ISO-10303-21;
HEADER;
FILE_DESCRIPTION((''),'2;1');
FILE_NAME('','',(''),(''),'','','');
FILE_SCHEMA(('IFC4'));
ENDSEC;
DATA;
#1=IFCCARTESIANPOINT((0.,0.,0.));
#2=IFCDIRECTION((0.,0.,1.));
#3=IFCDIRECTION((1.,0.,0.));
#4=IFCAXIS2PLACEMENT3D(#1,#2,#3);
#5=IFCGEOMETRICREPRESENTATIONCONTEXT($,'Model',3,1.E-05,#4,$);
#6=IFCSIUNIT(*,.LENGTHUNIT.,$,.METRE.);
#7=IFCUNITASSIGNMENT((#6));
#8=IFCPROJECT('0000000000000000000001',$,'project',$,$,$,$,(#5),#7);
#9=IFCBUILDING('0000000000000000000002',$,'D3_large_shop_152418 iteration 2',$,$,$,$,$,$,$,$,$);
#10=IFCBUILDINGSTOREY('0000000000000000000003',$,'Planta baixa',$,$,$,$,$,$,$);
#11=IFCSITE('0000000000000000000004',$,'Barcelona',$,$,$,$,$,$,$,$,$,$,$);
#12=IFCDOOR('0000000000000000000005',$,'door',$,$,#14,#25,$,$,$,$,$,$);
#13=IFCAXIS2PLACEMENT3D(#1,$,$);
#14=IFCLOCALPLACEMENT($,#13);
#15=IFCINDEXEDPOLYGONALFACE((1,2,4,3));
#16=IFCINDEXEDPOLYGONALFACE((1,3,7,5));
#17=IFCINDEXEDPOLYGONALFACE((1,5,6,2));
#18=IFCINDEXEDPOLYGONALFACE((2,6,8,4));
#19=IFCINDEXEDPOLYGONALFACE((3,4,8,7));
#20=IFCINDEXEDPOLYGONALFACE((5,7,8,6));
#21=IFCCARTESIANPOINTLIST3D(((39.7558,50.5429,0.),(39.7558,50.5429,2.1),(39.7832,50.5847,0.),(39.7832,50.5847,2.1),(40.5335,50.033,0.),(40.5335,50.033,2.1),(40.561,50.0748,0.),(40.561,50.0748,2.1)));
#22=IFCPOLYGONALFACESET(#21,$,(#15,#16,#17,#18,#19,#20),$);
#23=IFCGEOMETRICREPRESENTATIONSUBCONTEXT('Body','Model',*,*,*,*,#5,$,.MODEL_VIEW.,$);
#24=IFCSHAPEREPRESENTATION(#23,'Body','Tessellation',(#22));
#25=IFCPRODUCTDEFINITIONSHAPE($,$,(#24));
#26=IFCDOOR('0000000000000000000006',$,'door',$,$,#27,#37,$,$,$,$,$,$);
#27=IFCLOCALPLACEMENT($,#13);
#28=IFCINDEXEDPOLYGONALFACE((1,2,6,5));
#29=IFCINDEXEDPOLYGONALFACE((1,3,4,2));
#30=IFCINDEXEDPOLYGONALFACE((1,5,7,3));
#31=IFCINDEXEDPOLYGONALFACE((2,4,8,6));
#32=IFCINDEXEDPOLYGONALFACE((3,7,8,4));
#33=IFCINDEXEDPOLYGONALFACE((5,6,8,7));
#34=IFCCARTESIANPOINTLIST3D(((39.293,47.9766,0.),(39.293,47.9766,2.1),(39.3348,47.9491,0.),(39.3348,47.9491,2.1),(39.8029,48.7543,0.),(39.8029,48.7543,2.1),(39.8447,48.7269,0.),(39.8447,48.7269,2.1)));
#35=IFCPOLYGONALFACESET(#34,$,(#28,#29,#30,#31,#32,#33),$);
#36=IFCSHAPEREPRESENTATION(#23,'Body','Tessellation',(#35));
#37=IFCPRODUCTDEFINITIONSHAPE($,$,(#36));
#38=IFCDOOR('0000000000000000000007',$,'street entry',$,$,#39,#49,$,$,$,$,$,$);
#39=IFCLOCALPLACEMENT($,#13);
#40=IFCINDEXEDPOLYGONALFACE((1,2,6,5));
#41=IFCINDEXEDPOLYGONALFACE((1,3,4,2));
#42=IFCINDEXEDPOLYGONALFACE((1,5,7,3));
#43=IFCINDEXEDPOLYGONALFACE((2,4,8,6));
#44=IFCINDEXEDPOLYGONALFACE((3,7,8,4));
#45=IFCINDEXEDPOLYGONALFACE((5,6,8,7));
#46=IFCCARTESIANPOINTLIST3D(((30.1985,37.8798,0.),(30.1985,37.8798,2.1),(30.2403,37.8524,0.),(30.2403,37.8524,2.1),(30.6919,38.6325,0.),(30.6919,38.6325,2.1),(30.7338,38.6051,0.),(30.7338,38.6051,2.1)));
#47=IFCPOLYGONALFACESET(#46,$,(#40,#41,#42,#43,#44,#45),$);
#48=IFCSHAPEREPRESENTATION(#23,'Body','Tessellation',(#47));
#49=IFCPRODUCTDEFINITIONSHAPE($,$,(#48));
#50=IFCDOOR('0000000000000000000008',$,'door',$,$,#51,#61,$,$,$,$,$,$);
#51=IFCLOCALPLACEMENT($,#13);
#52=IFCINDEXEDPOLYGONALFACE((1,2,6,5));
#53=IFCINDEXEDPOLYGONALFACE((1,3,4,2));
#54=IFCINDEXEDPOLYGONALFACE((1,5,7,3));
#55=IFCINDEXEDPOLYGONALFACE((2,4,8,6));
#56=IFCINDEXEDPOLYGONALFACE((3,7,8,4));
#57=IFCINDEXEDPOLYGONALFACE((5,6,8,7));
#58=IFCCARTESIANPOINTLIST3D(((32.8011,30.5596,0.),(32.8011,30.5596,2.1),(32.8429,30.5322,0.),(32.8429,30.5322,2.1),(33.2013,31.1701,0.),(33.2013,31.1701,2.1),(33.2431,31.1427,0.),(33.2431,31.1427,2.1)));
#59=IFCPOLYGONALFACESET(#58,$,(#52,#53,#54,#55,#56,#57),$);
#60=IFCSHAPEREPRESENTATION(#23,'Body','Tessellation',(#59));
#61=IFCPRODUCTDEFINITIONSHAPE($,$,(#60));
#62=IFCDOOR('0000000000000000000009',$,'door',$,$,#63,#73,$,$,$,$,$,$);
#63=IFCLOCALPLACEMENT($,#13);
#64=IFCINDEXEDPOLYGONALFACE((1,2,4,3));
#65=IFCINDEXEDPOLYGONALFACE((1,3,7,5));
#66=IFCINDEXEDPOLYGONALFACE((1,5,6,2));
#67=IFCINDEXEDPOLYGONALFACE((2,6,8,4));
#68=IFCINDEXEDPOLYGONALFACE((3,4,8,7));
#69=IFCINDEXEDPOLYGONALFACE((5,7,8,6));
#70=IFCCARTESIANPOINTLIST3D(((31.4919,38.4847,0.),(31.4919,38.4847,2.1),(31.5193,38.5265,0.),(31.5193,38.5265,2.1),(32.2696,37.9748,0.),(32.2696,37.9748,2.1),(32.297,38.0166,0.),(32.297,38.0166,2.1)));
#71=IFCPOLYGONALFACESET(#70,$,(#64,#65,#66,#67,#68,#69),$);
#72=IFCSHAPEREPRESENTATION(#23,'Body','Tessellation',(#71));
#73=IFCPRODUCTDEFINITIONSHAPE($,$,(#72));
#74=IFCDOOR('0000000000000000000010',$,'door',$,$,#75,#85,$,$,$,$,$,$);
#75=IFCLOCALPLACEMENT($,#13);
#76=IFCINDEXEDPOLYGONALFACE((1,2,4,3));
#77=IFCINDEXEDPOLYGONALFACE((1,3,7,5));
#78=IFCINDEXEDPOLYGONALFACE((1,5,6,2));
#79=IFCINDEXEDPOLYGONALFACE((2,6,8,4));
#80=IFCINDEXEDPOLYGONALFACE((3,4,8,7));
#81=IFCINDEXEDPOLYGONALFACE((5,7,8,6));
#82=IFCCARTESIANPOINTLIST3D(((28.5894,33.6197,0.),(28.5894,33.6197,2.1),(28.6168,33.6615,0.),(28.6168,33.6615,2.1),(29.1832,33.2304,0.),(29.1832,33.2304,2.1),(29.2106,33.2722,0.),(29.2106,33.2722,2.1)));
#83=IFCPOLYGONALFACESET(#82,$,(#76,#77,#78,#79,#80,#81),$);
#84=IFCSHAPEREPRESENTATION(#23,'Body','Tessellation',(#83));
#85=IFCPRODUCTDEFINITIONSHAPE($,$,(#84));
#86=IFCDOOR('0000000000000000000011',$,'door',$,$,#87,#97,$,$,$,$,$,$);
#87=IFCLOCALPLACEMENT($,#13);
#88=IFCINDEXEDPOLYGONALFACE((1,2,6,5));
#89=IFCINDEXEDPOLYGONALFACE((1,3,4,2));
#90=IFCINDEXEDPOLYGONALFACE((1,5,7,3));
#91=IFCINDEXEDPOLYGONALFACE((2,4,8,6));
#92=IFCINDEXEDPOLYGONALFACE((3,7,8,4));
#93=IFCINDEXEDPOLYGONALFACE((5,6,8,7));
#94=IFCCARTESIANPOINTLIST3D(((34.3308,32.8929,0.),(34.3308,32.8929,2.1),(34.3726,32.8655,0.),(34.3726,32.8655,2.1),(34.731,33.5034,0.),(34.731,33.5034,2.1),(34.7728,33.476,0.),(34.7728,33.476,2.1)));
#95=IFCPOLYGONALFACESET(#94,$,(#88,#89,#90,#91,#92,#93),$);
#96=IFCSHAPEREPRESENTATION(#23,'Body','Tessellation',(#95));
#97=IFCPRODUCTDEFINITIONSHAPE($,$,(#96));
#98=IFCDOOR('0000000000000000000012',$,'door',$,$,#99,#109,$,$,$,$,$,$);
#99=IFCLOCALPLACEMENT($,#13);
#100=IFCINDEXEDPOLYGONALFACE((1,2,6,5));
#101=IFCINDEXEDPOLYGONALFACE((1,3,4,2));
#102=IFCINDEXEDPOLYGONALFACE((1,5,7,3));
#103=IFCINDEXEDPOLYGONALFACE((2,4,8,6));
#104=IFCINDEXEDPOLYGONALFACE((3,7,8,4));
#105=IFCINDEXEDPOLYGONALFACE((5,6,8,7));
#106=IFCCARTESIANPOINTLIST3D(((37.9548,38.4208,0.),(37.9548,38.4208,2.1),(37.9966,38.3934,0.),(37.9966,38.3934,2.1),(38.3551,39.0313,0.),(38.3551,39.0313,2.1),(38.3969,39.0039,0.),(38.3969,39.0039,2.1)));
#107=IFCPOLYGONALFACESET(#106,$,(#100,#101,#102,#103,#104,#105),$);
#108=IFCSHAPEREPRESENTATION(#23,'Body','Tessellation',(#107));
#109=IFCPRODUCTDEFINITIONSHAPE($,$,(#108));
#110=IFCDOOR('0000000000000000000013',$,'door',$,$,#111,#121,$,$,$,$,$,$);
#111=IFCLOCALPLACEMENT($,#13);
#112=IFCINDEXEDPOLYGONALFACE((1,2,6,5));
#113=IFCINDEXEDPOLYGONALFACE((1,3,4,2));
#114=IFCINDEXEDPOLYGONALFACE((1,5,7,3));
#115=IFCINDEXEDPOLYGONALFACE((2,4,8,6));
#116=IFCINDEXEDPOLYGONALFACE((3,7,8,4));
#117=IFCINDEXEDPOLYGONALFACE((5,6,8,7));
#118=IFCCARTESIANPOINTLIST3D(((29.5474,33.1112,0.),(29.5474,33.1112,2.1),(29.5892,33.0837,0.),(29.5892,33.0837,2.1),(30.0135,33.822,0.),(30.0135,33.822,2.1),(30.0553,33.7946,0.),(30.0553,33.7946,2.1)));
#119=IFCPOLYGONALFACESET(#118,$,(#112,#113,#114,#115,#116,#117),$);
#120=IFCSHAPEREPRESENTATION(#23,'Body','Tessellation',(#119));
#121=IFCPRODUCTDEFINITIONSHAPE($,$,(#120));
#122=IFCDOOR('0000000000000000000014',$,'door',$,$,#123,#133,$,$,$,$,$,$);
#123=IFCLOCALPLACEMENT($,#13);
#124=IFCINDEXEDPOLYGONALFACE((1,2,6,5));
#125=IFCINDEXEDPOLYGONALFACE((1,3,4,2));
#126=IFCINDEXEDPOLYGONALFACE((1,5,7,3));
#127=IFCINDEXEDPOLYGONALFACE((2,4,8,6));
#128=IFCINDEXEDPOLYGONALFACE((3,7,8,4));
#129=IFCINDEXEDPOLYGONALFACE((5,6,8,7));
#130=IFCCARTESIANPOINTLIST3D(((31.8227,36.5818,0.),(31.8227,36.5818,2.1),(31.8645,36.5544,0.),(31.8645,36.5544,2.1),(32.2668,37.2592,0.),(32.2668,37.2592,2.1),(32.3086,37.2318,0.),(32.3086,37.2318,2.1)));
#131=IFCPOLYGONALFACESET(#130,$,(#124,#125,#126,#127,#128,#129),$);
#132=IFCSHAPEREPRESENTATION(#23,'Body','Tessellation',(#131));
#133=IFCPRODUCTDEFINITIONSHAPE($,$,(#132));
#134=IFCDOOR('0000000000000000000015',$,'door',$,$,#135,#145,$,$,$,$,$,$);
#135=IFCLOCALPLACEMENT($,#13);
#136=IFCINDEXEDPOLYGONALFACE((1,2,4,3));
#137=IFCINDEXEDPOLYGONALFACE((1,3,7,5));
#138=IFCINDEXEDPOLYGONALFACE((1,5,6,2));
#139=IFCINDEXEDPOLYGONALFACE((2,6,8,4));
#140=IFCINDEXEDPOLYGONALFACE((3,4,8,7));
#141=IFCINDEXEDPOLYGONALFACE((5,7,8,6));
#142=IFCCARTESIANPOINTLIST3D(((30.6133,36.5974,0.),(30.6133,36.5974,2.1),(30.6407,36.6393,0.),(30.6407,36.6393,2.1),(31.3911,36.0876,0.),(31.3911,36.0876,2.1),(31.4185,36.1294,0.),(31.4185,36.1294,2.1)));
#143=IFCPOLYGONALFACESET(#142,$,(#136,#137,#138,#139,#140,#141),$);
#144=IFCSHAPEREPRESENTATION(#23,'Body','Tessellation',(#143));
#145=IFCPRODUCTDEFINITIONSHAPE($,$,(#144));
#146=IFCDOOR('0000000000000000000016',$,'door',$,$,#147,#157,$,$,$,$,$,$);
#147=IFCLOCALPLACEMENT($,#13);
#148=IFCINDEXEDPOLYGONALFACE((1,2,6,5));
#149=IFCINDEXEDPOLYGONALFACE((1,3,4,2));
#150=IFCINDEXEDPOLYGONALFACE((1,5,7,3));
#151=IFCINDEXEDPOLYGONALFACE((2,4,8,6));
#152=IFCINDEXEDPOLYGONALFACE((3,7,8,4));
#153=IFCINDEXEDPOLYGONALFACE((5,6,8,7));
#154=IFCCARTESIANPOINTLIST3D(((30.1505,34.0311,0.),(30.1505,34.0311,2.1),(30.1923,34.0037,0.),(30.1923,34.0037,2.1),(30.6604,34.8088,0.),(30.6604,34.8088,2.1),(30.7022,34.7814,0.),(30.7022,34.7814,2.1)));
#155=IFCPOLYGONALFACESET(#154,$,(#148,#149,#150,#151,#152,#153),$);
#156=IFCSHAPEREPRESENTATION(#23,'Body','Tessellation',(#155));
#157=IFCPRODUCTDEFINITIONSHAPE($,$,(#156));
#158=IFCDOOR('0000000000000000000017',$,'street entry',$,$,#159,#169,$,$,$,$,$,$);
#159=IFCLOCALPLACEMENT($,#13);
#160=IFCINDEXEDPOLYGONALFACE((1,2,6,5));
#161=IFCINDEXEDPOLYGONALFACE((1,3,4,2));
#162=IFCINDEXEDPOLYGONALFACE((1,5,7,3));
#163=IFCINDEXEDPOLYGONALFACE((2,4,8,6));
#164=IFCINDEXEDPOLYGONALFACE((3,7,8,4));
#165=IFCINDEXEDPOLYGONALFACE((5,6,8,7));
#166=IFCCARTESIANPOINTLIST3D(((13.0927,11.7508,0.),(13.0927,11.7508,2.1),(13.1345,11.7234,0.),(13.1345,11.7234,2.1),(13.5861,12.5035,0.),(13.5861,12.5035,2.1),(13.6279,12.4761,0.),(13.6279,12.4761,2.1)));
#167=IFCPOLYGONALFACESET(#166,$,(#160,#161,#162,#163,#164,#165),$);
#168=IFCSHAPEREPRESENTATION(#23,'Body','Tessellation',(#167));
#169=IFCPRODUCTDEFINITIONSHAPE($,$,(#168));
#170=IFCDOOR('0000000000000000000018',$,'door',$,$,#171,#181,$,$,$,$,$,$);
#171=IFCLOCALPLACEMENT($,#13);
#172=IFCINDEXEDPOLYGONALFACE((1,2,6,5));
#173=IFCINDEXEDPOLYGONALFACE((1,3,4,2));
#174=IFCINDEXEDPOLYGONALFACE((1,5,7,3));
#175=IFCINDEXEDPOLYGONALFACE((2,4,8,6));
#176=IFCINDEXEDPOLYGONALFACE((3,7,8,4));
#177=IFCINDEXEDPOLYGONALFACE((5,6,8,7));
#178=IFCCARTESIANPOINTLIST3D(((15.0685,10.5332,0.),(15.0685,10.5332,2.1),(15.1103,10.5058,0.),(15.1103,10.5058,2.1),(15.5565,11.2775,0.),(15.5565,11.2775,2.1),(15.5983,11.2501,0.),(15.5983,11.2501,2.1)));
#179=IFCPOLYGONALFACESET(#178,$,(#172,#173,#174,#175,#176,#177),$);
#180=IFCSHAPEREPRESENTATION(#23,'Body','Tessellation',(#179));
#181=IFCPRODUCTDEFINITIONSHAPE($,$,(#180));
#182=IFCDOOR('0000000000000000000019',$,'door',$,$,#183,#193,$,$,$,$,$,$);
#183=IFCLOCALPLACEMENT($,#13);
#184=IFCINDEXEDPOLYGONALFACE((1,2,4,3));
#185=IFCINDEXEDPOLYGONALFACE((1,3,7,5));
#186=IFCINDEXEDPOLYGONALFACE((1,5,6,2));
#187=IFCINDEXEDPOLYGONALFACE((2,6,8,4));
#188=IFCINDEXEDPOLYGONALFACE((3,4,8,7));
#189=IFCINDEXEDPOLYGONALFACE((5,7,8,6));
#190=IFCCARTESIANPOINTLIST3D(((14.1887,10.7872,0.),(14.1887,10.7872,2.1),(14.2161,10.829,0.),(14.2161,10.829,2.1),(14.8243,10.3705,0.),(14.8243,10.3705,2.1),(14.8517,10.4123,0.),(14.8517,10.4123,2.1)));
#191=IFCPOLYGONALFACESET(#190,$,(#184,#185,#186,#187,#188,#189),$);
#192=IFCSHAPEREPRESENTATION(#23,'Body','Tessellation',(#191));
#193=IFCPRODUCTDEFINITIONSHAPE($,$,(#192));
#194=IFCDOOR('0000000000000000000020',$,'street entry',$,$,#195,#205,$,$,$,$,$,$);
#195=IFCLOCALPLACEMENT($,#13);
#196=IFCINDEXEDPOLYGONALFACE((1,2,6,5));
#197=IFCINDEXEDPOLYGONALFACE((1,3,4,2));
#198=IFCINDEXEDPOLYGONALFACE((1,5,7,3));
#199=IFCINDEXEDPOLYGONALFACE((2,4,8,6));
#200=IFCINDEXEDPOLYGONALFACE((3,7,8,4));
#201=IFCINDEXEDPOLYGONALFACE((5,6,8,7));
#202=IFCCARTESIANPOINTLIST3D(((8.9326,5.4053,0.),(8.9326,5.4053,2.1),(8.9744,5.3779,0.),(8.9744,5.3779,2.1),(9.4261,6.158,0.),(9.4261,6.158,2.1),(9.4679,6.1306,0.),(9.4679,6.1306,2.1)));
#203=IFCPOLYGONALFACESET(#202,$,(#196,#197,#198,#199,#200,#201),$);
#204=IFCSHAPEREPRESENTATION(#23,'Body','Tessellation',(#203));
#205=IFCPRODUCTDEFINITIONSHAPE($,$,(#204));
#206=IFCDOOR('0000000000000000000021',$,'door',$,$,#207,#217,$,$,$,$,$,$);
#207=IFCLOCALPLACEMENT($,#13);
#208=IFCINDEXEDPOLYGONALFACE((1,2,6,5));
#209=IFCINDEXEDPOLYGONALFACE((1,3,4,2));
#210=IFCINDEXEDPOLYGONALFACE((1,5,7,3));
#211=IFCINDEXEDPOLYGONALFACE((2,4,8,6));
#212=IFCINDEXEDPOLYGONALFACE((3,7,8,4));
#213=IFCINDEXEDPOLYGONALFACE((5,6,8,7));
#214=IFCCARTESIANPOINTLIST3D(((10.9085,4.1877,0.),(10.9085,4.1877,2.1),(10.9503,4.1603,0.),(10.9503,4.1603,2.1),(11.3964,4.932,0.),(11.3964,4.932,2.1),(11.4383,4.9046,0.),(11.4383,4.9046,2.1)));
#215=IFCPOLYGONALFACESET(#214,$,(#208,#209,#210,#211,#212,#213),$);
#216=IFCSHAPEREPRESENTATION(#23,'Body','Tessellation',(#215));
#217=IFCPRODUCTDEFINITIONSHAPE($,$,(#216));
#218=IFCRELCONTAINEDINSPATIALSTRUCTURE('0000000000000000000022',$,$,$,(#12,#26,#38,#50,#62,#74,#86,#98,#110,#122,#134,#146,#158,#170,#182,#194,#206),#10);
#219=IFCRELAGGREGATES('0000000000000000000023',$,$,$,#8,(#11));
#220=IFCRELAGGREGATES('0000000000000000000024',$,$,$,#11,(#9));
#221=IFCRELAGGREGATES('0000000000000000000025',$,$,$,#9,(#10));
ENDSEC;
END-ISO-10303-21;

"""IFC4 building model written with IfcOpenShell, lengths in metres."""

from ifc_helpers import new_model, si_unit, origin, origin_with_axes, place, context, subcontext, project, spatial, polyline, outline, extrude, element, save


model = new_model("IFC4")

# Units and contexts
model_context = context("Model", 3, precision=1e-05, world=origin_with_axes())
body_context = subcontext(model_context, "Body", "Model", "MODEL_VIEW")
ifc_project = project(units=[si_unit("LENGTHUNIT", "METRE")], contexts=[model_context])

# Site, building, storey
site = spatial("IfcSite", under=ifc_project, Name="Barcelona")
building = spatial("IfcBuilding", under=site, Name="D3_large_shop_152418 iteration 2")
storey = spatial("IfcBuildingStorey", under=building, Name="Planta baixa")

# Doors
door_1_placement = place(None, origin_with_axes())
element("IfcDoor", 1, at=door_1_placement, inside=storey, Name="door", context=body_context, shape_type="SweptSolid", body=[
    extrude(outline(polyline([(39.7832, 50.5847), (40.561, 50.0748), (40.5335, 50.033), (39.7558, 50.5429), (39.7832, 50.5847)])), origin(), (0.0, 0.0, 1.0), 2.1),
])
door_2_placement = place(None, origin_with_axes())
element("IfcDoor", 2, at=door_2_placement, inside=storey, Name="door", context=body_context, shape_type="SweptSolid", body=[
    extrude(outline(polyline([(39.8447, 48.7269), (39.3348, 47.9491), (39.293, 47.9766), (39.8029, 48.7543), (39.8447, 48.7269)])), origin(), (0.0, 0.0, 1.0), 2.1),
])
door_3_placement = place(None, origin_with_axes())
element("IfcDoor", 3, at=door_3_placement, inside=storey, Name="street entry", context=body_context, shape_type="SweptSolid", body=[
    extrude(outline(polyline([(30.7338, 38.6051), (30.2403, 37.8524), (30.1985, 37.8798), (30.6919, 38.6325), (30.7338, 38.6051)])), origin(), (0.0, 0.0, 1.0), 2.1),
])
door_4_placement = place(None, origin_with_axes())
element("IfcDoor", 4, at=door_4_placement, inside=storey, Name="door", context=body_context, shape_type="SweptSolid", body=[
    extrude(outline(polyline([(32.8011, 30.5596), (33.2013, 31.1701), (33.2431, 31.1427), (32.8429, 30.5322), (32.8011, 30.5596)])), origin(), (0.0, 0.0, 1.0), 2.1),
])
door_5_placement = place(None, origin_with_axes())
element("IfcDoor", 5, at=door_5_placement, inside=storey, Name="door", context=body_context, shape_type="SweptSolid", body=[
    extrude(outline(polyline([(32.2696, 37.9748), (31.4919, 38.4847), (31.5193, 38.5265), (32.297, 38.0166), (32.2696, 37.9748)])), origin(), (0.0, 0.0, 1.0), 2.1),
])
door_6_placement = place(None, origin_with_axes())
element("IfcDoor", 6, at=door_6_placement, inside=storey, Name="door", context=body_context, shape_type="SweptSolid", body=[
    extrude(outline(polyline([(29.1832, 33.2304), (28.5894, 33.6197), (28.6168, 33.6615), (29.2106, 33.2722), (29.1832, 33.2304)])), origin(), (0.0, 0.0, 1.0), 2.1),
])
door_7_placement = place(None, origin_with_axes())
element("IfcDoor", 7, at=door_7_placement, inside=storey, Name="door", context=body_context, shape_type="SweptSolid", body=[
    extrude(outline(polyline([(34.7728, 33.476), (34.3726, 32.8655), (34.3308, 32.8929), (34.731, 33.5034), (34.7728, 33.476)])), origin(), (0.0, 0.0, 1.0), 2.1),
])
door_8_placement = place(None, origin_with_axes())
element("IfcDoor", 8, at=door_8_placement, inside=storey, Name="door", context=body_context, shape_type="SweptSolid", body=[
    extrude(outline(polyline([(38.3969, 39.0039), (37.9966, 38.3934), (37.9548, 38.4208), (38.3551, 39.0313), (38.3969, 39.0039)])), origin(), (0.0, 0.0, 1.0), 2.1),
])
door_9_placement = place(None, origin_with_axes())
element("IfcDoor", 9, at=door_9_placement, inside=storey, Name="door", context=body_context, shape_type="SweptSolid", body=[
    extrude(outline(polyline([(30.0553, 33.7946), (29.5892, 33.0837), (29.5474, 33.1112), (30.0135, 33.822), (30.0553, 33.7946)])), origin(), (0.0, 0.0, 1.0), 2.1),
])
door_10_placement = place(None, origin_with_axes())
element("IfcDoor", 10, at=door_10_placement, inside=storey, Name="door", context=body_context, shape_type="SweptSolid", body=[
    extrude(outline(polyline([(32.3086, 37.2318), (31.8645, 36.5544), (31.8227, 36.5818), (32.2668, 37.2592), (32.3086, 37.2318)])), origin(), (0.0, 0.0, 1.0), 2.1),
])
door_11_placement = place(None, origin_with_axes())
element("IfcDoor", 11, at=door_11_placement, inside=storey, Name="door", context=body_context, shape_type="SweptSolid", body=[
    extrude(outline(polyline([(30.6407, 36.6393), (31.4185, 36.1294), (31.3911, 36.0876), (30.6133, 36.5974), (30.6407, 36.6393)])), origin(), (0.0, 0.0, 1.0), 2.1),
])
door_12_placement = place(None, origin_with_axes())
element("IfcDoor", 12, at=door_12_placement, inside=storey, Name="door", context=body_context, shape_type="SweptSolid", body=[
    extrude(outline(polyline([(30.7022, 34.7814), (30.1923, 34.0037), (30.1505, 34.0311), (30.6604, 34.8088), (30.7022, 34.7814)])), origin(), (0.0, 0.0, 1.0), 2.1),
])
door_13_placement = place(None, origin_with_axes())
element("IfcDoor", 13, at=door_13_placement, inside=storey, Name="street entry", context=body_context, shape_type="SweptSolid", body=[
    extrude(outline(polyline([(13.6279, 12.4761), (13.1345, 11.7234), (13.0927, 11.7508), (13.5861, 12.5035), (13.6279, 12.4761)])), origin(), (0.0, 0.0, 1.0), 2.1),
])
door_14_placement = place(None, origin_with_axes())
element("IfcDoor", 14, at=door_14_placement, inside=storey, Name="door", context=body_context, shape_type="SweptSolid", body=[
    extrude(outline(polyline([(15.5983, 11.2501), (15.1103, 10.5058), (15.0685, 10.5332), (15.5565, 11.2775), (15.5983, 11.2501)])), origin(), (0.0, 0.0, 1.0), 2.1),
])
door_15_placement = place(None, origin_with_axes())
element("IfcDoor", 15, at=door_15_placement, inside=storey, Name="door", context=body_context, shape_type="SweptSolid", body=[
    extrude(outline(polyline([(14.8243, 10.3705), (14.1887, 10.7872), (14.2161, 10.829), (14.8517, 10.4123), (14.8243, 10.3705)])), origin(), (0.0, 0.0, 1.0), 2.1),
])
door_16_placement = place(None, origin_with_axes())
element("IfcDoor", 16, at=door_16_placement, inside=storey, Name="street entry", context=body_context, shape_type="SweptSolid", body=[
    extrude(outline(polyline([(9.4679, 6.1306), (8.9744, 5.3779), (8.9326, 5.4053), (9.4261, 6.158), (9.4679, 6.1306)])), origin(), (0.0, 0.0, 1.0), 2.1),
])
door_17_placement = place(None, origin_with_axes())
element("IfcDoor", 17, at=door_17_placement, inside=storey, Name="door", context=body_context, shape_type="SweptSolid", body=[
    extrude(outline(polyline([(11.4383, 4.9046), (10.9503, 4.1603), (10.9085, 4.1877), (11.3964, 4.932), (11.4383, 4.9046)])), origin(), (0.0, 0.0, 1.0), 2.1),
])

save(model, "model.ifc")
